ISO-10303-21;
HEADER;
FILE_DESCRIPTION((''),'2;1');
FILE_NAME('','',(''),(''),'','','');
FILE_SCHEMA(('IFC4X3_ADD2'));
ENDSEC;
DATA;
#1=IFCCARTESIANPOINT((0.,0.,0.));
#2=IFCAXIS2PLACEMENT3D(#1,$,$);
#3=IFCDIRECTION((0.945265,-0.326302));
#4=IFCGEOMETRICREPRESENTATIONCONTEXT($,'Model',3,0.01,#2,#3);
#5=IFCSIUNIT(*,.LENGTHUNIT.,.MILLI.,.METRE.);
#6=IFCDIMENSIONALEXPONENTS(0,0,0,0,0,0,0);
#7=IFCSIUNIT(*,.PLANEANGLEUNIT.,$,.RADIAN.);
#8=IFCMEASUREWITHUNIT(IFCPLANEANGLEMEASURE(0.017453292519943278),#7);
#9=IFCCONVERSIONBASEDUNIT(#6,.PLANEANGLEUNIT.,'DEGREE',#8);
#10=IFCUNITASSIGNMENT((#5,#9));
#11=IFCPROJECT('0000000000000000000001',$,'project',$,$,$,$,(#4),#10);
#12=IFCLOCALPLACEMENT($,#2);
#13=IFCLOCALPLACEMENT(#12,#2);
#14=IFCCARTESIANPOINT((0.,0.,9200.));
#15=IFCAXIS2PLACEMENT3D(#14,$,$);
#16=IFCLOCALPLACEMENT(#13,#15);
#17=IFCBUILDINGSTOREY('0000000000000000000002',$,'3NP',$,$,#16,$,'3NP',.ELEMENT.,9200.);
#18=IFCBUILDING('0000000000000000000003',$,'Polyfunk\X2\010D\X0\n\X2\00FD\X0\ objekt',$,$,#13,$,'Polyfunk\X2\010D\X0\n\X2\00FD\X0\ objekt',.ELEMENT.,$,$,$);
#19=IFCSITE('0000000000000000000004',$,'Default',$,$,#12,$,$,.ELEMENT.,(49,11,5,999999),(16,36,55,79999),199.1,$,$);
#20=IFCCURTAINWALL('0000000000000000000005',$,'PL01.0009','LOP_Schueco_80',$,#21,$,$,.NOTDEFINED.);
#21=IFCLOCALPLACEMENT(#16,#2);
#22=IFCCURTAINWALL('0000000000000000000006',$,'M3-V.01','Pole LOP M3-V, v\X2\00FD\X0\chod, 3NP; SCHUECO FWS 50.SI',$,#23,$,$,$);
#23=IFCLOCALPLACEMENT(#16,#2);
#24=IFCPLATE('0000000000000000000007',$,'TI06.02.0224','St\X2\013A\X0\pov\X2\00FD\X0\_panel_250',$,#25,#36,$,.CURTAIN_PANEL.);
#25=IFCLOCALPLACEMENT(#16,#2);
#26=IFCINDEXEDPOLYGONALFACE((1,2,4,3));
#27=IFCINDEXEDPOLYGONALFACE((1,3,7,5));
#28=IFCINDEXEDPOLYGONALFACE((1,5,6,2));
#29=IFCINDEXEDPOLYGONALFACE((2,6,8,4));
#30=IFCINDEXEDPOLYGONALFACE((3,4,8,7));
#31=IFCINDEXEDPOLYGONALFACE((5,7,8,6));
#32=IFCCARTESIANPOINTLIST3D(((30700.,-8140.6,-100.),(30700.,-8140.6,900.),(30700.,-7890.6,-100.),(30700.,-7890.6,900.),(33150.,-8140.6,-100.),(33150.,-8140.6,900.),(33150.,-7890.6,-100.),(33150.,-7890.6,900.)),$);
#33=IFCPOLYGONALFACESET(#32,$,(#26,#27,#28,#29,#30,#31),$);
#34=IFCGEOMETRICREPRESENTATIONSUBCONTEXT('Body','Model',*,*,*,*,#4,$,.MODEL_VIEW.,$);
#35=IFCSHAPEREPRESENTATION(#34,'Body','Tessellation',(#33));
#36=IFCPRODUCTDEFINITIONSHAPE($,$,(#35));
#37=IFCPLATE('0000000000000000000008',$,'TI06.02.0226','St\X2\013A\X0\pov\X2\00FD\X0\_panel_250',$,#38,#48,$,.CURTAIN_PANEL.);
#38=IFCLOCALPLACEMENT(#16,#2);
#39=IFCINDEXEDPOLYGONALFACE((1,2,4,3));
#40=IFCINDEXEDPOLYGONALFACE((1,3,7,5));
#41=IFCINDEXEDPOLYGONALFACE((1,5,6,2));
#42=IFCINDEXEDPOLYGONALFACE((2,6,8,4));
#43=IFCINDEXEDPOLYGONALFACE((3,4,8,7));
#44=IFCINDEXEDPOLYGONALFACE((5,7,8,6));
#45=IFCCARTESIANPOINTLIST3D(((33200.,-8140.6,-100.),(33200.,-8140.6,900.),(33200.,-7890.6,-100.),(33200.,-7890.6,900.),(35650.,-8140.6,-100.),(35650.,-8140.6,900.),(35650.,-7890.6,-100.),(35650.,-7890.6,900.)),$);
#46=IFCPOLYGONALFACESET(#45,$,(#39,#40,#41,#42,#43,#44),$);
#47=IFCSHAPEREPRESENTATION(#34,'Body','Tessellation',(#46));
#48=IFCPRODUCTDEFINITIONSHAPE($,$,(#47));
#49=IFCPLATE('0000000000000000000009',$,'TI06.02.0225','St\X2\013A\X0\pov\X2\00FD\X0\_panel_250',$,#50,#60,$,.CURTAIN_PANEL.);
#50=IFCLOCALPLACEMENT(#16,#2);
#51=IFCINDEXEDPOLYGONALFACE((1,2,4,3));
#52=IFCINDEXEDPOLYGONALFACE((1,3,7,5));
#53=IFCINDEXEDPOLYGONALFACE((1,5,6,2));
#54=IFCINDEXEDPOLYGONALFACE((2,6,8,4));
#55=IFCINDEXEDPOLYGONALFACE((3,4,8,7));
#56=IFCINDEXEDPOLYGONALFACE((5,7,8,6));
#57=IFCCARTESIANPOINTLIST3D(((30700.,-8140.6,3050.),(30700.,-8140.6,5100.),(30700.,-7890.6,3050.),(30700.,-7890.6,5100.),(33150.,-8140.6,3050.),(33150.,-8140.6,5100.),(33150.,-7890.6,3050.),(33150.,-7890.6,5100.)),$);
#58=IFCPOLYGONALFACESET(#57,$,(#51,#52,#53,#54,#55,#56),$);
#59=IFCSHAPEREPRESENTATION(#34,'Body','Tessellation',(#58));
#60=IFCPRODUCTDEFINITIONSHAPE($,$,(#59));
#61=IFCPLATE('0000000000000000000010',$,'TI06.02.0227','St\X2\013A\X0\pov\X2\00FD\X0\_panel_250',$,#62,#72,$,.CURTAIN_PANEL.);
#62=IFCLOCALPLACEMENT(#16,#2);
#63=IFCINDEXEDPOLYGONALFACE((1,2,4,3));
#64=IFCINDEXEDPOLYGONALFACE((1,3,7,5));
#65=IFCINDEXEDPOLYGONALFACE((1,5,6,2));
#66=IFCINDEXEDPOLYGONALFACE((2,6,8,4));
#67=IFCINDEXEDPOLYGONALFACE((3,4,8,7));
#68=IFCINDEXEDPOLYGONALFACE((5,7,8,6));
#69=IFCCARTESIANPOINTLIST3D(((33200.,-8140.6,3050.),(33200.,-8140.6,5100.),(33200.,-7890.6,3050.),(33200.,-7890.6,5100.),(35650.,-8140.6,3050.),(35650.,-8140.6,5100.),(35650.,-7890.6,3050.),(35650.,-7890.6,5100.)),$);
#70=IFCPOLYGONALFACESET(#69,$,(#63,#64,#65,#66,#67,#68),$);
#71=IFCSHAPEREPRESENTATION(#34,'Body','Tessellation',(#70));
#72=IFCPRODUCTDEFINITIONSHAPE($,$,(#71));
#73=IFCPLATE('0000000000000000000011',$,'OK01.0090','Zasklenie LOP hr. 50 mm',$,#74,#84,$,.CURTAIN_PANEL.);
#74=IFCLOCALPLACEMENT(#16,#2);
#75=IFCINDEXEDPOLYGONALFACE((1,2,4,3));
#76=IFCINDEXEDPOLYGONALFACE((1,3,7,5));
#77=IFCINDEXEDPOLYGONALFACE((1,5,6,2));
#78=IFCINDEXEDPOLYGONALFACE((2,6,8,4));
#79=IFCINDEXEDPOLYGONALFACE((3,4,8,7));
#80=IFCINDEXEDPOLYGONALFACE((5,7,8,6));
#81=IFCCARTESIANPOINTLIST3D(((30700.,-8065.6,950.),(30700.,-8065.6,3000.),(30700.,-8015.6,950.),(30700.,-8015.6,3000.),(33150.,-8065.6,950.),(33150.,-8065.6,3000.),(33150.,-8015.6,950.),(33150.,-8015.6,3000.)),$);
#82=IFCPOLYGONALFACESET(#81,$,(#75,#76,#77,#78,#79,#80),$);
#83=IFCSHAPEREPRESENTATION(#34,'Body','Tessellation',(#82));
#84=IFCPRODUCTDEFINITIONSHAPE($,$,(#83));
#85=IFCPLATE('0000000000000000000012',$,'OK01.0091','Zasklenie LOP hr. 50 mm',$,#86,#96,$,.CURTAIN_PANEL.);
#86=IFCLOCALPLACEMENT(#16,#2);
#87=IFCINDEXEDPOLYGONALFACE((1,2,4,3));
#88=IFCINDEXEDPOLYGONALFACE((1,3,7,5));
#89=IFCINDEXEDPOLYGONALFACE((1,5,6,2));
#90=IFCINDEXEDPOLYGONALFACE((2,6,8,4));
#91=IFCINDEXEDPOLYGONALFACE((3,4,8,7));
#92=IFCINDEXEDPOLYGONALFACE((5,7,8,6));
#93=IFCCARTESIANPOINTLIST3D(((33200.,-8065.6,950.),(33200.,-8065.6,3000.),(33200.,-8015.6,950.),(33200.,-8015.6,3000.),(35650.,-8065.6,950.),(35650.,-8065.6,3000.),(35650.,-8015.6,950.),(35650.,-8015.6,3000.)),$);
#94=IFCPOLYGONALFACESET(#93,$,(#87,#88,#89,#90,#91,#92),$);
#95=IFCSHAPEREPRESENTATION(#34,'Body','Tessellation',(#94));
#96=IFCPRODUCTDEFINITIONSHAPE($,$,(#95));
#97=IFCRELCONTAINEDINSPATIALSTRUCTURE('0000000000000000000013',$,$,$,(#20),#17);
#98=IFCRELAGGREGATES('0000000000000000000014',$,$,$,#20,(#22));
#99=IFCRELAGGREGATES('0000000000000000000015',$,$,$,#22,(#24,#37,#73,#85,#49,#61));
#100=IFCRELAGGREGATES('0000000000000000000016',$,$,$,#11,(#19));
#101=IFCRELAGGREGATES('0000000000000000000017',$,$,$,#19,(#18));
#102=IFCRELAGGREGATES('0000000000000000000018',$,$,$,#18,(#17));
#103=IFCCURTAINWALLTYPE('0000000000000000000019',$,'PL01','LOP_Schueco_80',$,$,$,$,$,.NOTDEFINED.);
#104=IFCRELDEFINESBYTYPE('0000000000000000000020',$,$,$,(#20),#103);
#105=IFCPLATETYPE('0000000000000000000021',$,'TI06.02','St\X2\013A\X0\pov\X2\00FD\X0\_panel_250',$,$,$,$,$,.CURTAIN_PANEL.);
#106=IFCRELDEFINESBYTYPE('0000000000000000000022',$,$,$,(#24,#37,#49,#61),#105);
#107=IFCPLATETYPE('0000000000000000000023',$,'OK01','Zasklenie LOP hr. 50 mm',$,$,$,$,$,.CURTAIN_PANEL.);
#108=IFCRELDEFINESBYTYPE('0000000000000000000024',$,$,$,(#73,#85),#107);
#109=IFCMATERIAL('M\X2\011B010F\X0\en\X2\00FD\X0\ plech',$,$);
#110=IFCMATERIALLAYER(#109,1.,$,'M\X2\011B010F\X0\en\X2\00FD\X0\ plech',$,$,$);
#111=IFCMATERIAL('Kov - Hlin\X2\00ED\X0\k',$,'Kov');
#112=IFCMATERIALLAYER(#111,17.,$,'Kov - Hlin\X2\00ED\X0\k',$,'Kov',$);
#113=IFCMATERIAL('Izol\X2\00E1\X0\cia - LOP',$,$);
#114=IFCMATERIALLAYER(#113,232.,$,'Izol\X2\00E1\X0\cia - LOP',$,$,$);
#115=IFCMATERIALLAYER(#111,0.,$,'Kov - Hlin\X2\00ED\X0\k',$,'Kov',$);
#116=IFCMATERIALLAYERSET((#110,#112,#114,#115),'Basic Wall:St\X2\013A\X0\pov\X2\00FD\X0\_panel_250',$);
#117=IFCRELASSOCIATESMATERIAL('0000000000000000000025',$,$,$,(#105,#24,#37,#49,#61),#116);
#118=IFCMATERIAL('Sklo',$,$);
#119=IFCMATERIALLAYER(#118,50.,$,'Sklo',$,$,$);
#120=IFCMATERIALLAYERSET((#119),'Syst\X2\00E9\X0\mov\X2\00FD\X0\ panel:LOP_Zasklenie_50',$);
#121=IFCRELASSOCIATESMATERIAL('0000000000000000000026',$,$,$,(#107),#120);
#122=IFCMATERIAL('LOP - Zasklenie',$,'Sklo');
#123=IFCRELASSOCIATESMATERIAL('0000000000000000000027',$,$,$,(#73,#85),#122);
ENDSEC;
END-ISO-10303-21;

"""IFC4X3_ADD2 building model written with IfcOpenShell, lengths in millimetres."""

from ifc_helpers import new_model, entity, si_unit, converted_unit, direction, frame, frame_2d, origin, origin_2d_with_axis, place, context, subcontext, project, spatial, rectangle, extrude, source, transform, mapped, material, layer, layer_set, layer_usage, type_object, type_shapes, element, aggregate, save


model = new_model("IFC4X3_ADD2")

# Units and contexts
model_context = context("Model", 3, precision=0.01, world=origin(), true_north=direction((0.945265, -0.326302)))
body_context = subcontext(model_context, "Body", "Model", "MODEL_VIEW")
ifc_project = project(units=[si_unit("LENGTHUNIT", "METRE", prefix="MILLI"), converted_unit("PLANEANGLEUNIT", "DEGREE", entity("IfcPlaneAngleMeasure", 0.017453292519943278), si_unit("PLANEANGLEUNIT", "RADIAN"), dimensions=[0, 0, 0, 0, 0, 0, 0])], contexts=[model_context])

# Site, building, storey
site_placement = place(None, origin())
site = spatial("IfcSite", under=ifc_project, at=site_placement, Name="Default", CompositionType="ELEMENT", RefLatitude=(49, 11, 5, 999999), RefLongitude=(16, 36, 55, 79999), RefElevation=199.1)
building_placement = place(site_placement, origin())
building = spatial("IfcBuilding", under=site, at=building_placement, Name="Polyfunkčný objekt", LongName="Polyfunkčný objekt", CompositionType="ELEMENT")
storey_placement = place(building_placement, frame((0.0, 0.0, 9200.0)))
storey = spatial("IfcBuildingStorey", under=building, at=storey_placement, Name="3NP", LongName="3NP", CompositionType="ELEMENT", Elevation=9200.0)

# Curtain walls, plates
curtain_wall_type = type_object("IfcCurtainWallType", Name="PL01", Description="LOP_Schueco_80", PredefinedType="NOTDEFINED")
curtain_wall_1_placement = place(storey_placement, frame((0.0, 0.0, -9200.0)))
curtain_wall_1 = element("IfcCurtainWall", 1, at=curtain_wall_1_placement, inside=storey, type_object=curtain_wall_type, Name="PL01.0009", Description="LOP_Schueco_80", PredefinedType="NOTDEFINED")
curtain_wall_2 = element("IfcCurtainWall", 2, Name="M3-V.01", Description="Pole LOP M3-V, východ, 3NP; SCHUECO FWS 50.SI")
aggregate(curtain_wall_1, [curtain_wall_2])
ifc_material_1 = material(Name="Měďený plech")
ifc_layer_1 = layer(ifc_material_1, 1.0, Name="Měďený plech")
ifc_material_2 = material(Name="Kov - Hliník", Category="Kov")
ifc_layer_2 = layer(ifc_material_2, 17.0, Name="Kov - Hliník", Category="Kov")
ifc_material_3 = material(Name="Izolácia - LOP")
ifc_layer_3 = layer(ifc_material_3, 232.0, Name="Izolácia - LOP")
ifc_layer_4 = layer(ifc_material_2, 0.0, Name="Kov - Hliník", Category="Kov")
ifc_layer_set_1 = layer_set([ifc_layer_1, ifc_layer_2, ifc_layer_3, ifc_layer_4], Name="Basic Wall:Stĺpový_panel_250")
ifc_layer_usage_1 = layer_usage(ifc_layer_set_1, "AXIS2", "POSITIVE", -125.0)
plate_type_1 = type_object("IfcPlateType", Name="TI06.02", Description="Stĺpový_panel_250", PredefinedType="CURTAIN_PANEL", material=ifc_layer_set_1)
plate_1_placement = place(storey_placement, frame((30700.0, -8015.6, -100.0)))
plate_1 = element("IfcPlate", 3, at=plate_1_placement, type_object=plate_type_1, material=ifc_layer_usage_1, Name="TI06.02.0224", Description="Stĺpový_panel_250", PredefinedType="CURTAIN_PANEL", context=body_context, shape_type="SweptSolid", body=[
    extrude(rectangle(XDim=250.0, YDim=2450.0, at=frame_2d((0.0, 0.0), x_axis=(1.0, 0.0))), frame((1225.0, 0.0, 0.0), z_axis=(0.0, 0.0, 1.0), x_axis=(0.0, 1.0, 0.0)), (0.0, 0.0, 1.0), 1000.0),
])
ifc_layer_usage_2 = layer_usage(ifc_layer_set_1, "AXIS2", "POSITIVE", -125.0)
plate_2_placement = place(storey_placement, frame((33200.0, -8015.6, -100.0)))
plate_2 = element("IfcPlate", 4, at=plate_2_placement, type_object=plate_type_1, material=ifc_layer_usage_2, Name="TI06.02.0226", Description="Stĺpový_panel_250", PredefinedType="CURTAIN_PANEL", context=body_context, shape_type="SweptSolid", body=[
    extrude(rectangle(XDim=250.0, YDim=2450.0, at=frame_2d((0.0, 0.0), x_axis=(1.0, 0.0))), frame((1225.0, 0.0, 0.0), z_axis=(0.0, 0.0, 1.0), x_axis=(0.0, 1.0, 0.0)), (0.0, 0.0, 1.0), 1000.0),
])
ifc_layer_usage_3 = layer_usage(ifc_layer_set_1, "AXIS2", "POSITIVE", -125.0)
plate_3_placement = place(storey_placement, frame((30700.0, -8015.6, 3050.0)))
plate_3 = element("IfcPlate", 5, at=plate_3_placement, type_object=plate_type_1, material=ifc_layer_usage_3, Name="TI06.02.0225", Description="Stĺpový_panel_250", PredefinedType="CURTAIN_PANEL", context=body_context, shape_type="SweptSolid", body=[
    extrude(rectangle(XDim=250.0, YDim=2450.0, at=frame_2d((0.0, 0.0), x_axis=(1.0, 0.0))), frame((1225.0, 0.0, 0.0), z_axis=(0.0, 0.0, 1.0), x_axis=(0.0, 1.0, 0.0)), (0.0, 0.0, 1.0), 2050.0),
])
ifc_layer_usage_4 = layer_usage(ifc_layer_set_1, "AXIS2", "POSITIVE", -125.0)
plate_4_placement = place(storey_placement, frame((33200.0, -8015.6, 3050.0)))
plate_4 = element("IfcPlate", 6, at=plate_4_placement, type_object=plate_type_1, material=ifc_layer_usage_4, Name="TI06.02.0227", Description="Stĺpový_panel_250", PredefinedType="CURTAIN_PANEL", context=body_context, shape_type="SweptSolid", body=[
    extrude(rectangle(XDim=250.0, YDim=2450.0, at=frame_2d((0.0, 0.0), x_axis=(1.0, 0.0))), frame((1225.0, 0.0, 0.0), z_axis=(0.0, 0.0, 1.0), x_axis=(0.0, 1.0, 0.0)), (0.0, 0.0, 1.0), 2050.0),
])
ifc_material_4 = material(Name="LOP - Zasklenie", Category="Sklo")
ifc_material_5 = material(Name="Sklo")
ifc_layer_5 = layer(ifc_material_5, 50.0, Name="Sklo")
ifc_layer_set_2 = layer_set([ifc_layer_5], Name="Systémový panel:LOP_Zasklenie_50")
plate_type_2 = type_object("IfcPlateType", Name="OK01", Description="Zasklenie LOP hr. 50 mm", PredefinedType="CURTAIN_PANEL", material=ifc_layer_set_2)
shared_shape_1 = source(origin(), body_context, "Body", "SweptSolid", [
    extrude(rectangle(XDim=50.0, YDim=2450.0, at=origin_2d_with_axis()), frame((0.0, -25.0, 0.0), z_axis=(0.0, 0.0, 1.0), x_axis=(0.0, 1.0, 0.0)), (0.0, 0.0, 1.0), 2050.0),
])
type_shapes(plate_type_2, [shared_shape_1])
plate_5_placement = place(curtain_wall_1_placement, frame((31925.0, -8015.6, 10150.0)))
plate_5 = element("IfcPlate", 7, at=plate_5_placement, type_object=plate_type_2, material=ifc_material_4, Name="OK01.0090", Description="Zasklenie LOP hr. 50 mm", PredefinedType="CURTAIN_PANEL", context=body_context, shape_type="MappedRepresentation", body=[
    mapped(shared_shape_1, transform((0.0, 0.0, 0.0), scale=1.0)),
])
plate_6_placement = place(curtain_wall_1_placement, frame((34425.0, -8015.6, 10150.0)))
plate_6 = element("IfcPlate", 8, at=plate_6_placement, type_object=plate_type_2, material=ifc_material_4, Name="OK01.0091", Description="Zasklenie LOP hr. 50 mm", PredefinedType="CURTAIN_PANEL", context=body_context, shape_type="MappedRepresentation", body=[
    mapped(shared_shape_1, transform((0.0, 0.0, 0.0), scale=1.0)),
])
aggregate(curtain_wall_2, [plate_1, plate_2, plate_5, plate_6, plate_3, plate_4])

save(model, "model.ifc")
